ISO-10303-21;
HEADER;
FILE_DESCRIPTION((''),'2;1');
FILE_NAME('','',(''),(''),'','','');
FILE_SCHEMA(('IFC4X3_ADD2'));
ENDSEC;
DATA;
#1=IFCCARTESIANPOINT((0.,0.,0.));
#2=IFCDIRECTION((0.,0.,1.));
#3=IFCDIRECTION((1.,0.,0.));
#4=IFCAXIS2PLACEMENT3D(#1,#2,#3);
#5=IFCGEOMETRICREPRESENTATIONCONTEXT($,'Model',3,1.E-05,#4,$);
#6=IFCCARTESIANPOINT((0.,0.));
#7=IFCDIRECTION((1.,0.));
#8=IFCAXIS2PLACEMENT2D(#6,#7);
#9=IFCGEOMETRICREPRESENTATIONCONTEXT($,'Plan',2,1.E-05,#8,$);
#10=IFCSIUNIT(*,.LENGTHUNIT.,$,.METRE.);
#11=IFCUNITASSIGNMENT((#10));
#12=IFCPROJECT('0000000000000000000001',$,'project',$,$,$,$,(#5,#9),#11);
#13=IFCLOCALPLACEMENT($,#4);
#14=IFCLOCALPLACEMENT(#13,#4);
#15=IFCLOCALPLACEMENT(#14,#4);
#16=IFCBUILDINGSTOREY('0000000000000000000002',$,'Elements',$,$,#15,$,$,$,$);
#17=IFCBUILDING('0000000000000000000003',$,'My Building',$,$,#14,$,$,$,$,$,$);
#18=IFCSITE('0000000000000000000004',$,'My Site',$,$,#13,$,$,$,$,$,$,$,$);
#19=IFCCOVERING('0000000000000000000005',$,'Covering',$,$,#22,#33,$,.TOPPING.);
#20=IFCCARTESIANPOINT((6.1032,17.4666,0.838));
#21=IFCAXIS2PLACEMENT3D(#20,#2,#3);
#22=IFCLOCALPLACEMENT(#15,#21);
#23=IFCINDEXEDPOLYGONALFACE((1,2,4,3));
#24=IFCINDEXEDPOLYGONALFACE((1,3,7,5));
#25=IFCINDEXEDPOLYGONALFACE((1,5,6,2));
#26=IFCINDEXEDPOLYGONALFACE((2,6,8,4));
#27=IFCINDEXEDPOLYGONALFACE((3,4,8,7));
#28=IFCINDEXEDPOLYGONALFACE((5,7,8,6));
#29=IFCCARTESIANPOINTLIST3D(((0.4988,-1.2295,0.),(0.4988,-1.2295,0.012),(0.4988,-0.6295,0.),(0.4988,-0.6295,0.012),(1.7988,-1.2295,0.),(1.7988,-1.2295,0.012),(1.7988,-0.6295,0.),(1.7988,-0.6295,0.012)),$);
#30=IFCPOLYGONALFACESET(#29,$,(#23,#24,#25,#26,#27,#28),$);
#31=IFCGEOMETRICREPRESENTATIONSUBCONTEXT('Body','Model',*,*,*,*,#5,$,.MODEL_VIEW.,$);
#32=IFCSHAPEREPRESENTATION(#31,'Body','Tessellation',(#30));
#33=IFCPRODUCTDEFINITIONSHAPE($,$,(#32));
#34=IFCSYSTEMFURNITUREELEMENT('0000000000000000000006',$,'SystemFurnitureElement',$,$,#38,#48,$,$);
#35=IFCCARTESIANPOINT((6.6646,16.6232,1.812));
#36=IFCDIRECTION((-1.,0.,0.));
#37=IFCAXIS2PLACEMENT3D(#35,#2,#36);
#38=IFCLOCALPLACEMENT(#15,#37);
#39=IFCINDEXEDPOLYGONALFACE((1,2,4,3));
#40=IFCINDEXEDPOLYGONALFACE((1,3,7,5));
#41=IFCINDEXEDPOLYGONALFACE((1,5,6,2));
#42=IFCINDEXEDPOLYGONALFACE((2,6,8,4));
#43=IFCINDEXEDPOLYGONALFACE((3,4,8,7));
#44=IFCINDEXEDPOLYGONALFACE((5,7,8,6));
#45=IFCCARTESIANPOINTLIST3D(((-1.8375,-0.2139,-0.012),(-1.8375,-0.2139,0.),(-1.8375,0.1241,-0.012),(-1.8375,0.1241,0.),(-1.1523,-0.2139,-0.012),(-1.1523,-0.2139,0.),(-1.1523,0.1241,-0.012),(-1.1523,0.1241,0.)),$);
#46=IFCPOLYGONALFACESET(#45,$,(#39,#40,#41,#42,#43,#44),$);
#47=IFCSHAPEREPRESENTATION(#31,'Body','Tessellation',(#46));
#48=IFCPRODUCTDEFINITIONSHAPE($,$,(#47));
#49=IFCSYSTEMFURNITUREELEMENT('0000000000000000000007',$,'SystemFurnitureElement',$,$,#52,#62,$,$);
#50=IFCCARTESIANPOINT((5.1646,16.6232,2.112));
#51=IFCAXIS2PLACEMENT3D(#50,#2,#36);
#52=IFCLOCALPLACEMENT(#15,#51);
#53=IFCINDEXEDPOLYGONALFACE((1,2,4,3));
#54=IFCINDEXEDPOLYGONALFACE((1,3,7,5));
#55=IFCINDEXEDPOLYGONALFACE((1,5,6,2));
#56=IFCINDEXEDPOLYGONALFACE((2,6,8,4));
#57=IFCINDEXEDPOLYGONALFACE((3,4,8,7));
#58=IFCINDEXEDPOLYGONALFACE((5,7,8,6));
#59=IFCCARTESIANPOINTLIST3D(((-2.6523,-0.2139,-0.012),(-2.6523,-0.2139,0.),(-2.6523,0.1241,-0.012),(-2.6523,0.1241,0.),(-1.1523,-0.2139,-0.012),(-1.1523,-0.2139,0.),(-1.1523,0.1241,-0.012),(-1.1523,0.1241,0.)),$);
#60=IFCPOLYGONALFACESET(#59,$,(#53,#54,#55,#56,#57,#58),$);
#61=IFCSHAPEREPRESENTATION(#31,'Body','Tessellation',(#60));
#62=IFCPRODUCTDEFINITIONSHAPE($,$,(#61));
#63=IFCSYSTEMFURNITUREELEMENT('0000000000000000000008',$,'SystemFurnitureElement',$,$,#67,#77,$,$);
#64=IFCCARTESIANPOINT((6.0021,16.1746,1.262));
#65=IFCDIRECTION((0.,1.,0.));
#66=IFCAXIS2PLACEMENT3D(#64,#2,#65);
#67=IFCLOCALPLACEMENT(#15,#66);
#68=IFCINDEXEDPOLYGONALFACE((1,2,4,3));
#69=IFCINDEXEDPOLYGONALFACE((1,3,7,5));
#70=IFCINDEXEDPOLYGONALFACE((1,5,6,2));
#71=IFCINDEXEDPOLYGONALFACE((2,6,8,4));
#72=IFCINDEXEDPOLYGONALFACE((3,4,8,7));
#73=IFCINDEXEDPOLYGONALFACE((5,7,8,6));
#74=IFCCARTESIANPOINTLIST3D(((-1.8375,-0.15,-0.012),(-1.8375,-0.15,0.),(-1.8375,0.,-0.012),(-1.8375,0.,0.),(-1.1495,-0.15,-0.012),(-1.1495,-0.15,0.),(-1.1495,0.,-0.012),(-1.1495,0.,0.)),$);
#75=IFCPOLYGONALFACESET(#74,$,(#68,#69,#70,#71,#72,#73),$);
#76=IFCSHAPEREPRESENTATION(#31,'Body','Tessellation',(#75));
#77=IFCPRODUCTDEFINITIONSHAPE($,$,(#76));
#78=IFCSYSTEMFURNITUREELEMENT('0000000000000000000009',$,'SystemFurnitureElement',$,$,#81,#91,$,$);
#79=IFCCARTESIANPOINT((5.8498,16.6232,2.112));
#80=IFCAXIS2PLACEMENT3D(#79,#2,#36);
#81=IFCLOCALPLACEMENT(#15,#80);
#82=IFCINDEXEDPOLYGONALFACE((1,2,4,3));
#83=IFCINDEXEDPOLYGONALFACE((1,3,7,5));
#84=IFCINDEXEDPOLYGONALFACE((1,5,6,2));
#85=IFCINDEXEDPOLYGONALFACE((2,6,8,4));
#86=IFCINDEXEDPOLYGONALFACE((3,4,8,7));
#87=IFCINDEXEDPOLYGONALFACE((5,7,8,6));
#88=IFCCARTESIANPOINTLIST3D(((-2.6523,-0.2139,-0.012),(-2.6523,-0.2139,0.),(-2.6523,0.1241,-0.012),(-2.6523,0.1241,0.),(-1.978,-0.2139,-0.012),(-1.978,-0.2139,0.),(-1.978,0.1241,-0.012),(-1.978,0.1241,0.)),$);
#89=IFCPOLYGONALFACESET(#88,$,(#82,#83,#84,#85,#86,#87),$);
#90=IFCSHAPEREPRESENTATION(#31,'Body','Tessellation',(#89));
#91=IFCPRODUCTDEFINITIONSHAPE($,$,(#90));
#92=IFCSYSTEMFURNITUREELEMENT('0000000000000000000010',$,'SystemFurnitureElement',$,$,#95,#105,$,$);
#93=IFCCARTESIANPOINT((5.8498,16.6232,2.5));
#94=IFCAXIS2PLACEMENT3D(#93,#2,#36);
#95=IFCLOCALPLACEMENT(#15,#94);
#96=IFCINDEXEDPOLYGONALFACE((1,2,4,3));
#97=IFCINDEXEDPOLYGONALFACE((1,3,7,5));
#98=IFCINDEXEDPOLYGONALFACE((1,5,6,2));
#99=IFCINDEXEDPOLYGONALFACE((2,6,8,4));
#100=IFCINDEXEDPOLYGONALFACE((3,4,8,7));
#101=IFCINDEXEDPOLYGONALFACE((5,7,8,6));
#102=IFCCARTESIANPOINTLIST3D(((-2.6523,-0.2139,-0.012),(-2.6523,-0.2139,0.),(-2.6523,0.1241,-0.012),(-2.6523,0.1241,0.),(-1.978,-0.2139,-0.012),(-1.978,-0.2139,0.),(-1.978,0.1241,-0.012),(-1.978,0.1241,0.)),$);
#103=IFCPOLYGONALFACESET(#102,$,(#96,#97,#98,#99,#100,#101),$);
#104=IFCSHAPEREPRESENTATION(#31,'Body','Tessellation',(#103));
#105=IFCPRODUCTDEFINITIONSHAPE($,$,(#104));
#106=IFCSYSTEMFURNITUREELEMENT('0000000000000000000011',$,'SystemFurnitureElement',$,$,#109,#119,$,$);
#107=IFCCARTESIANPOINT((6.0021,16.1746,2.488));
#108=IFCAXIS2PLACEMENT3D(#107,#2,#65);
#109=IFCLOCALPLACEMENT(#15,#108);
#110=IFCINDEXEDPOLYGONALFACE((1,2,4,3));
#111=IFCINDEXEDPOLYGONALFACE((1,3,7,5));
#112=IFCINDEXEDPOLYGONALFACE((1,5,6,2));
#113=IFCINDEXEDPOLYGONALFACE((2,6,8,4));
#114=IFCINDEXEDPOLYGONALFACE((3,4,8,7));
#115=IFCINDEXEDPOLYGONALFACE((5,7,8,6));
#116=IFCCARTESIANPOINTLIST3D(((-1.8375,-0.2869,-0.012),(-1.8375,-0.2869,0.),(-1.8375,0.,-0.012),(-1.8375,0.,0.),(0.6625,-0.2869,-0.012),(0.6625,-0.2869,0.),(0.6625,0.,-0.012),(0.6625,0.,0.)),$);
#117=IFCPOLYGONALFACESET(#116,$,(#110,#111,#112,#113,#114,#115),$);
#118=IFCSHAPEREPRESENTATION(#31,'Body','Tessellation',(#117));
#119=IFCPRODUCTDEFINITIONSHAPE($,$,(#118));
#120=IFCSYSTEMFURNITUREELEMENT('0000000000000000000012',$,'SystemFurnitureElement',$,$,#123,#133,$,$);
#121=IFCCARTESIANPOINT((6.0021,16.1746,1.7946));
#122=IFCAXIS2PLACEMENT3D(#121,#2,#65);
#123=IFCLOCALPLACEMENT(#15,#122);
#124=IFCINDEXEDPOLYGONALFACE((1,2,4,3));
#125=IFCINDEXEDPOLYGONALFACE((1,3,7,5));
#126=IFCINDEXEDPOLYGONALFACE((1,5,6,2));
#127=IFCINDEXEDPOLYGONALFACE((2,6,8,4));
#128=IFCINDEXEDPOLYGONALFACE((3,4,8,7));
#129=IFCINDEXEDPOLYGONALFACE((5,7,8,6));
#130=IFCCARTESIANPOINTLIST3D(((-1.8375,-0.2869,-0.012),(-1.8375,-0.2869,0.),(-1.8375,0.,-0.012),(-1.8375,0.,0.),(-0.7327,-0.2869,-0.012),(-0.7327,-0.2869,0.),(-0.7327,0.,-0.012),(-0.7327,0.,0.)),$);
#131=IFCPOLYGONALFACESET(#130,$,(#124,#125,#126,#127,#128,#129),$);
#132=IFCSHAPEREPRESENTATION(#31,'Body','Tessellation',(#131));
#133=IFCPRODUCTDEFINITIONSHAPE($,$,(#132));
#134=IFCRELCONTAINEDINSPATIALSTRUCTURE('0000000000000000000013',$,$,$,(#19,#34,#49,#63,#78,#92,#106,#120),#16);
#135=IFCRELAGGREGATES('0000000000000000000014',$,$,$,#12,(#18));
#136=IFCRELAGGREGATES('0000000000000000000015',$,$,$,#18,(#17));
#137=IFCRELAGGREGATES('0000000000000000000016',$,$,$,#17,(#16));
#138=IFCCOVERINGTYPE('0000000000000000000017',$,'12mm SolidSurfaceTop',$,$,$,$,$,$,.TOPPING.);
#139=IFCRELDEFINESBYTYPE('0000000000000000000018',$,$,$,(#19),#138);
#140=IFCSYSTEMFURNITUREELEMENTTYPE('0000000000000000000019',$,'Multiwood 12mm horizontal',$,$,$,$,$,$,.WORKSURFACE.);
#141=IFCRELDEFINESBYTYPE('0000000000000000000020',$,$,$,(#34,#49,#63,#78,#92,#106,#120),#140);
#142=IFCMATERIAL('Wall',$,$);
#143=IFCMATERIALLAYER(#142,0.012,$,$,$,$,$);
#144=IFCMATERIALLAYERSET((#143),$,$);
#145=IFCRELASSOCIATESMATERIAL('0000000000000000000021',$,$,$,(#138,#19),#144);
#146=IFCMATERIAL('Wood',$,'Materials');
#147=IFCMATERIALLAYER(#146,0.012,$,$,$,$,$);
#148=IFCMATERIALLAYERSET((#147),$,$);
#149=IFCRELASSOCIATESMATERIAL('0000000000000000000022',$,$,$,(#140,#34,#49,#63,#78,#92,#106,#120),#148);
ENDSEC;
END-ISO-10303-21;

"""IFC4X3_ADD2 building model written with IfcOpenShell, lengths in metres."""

from ifc_helpers import new_model, si_unit, frame, origin_with_axes, origin_2d_with_axis, place, context, subcontext, project, spatial, indexed_curve, outline, extrude, material, layer, layer_set, layer_usage, type_object, element, save


model = new_model("IFC4X3_ADD2")

# Units and contexts
model_context = context("Model", 3, precision=1e-05, world=origin_with_axes())
plan_context = context("Plan", 2, precision=1e-05, world=origin_2d_with_axis())
body_context = subcontext(model_context, "Body", "Model", "MODEL_VIEW")
ifc_project = project(units=[si_unit("LENGTHUNIT", "METRE")], contexts=[model_context, plan_context])

# Site, building, storey
site_placement = place(None, origin_with_axes())
site = spatial("IfcSite", under=ifc_project, at=site_placement, Name="My Site")
building_placement = place(site_placement, origin_with_axes())
building = spatial("IfcBuilding", under=site, at=building_placement, Name="My Building")
storey_placement = place(building_placement, origin_with_axes())
storey = spatial("IfcBuildingStorey", under=building, at=storey_placement, Name="Elements")

# Covering
ifc_material_1 = material(Name="Wall")
ifc_layer_1 = layer(ifc_material_1, 0.012)
ifc_layer_set_1 = layer_set([ifc_layer_1])
ifc_layer_usage_1 = layer_usage(ifc_layer_set_1, "AXIS3", "POSITIVE", 0.0)
covering_type = type_object("IfcCoveringType", Name="12mm SolidSurfaceTop", PredefinedType="TOPPING", material=ifc_layer_set_1)
covering_placement = place(storey_placement, frame((6.1032, 17.4666, 0.838), z_axis=(0.0, 0.0, 1.0), x_axis=(1.0, 0.0, 0.0)))
element("IfcCovering", 1, at=covering_placement, inside=storey, type_object=covering_type, material=ifc_layer_usage_1, Name="Covering", PredefinedType="TOPPING", context=body_context, shape_type="SweptSolid", body=[
    extrude(outline(indexed_curve([(0.4988, -1.2295), (1.7988, -1.2295), (1.7988, -0.6295), (0.4988, -0.6295), (0.4988, -1.2295)])), None, (0.0, 0.0, 1.0), 0.012),
])

# Shared definitions
ifc_material_2 = material(Name="Wood", Category="Materials")

# System furniture elements
ifc_layer_2 = layer(ifc_material_2, 0.012)
ifc_layer_set_2 = layer_set([ifc_layer_2])
ifc_layer_usage_2 = layer_usage(ifc_layer_set_2, "AXIS3", "POSITIVE", -0.012)
system_furniture_element_type_1 = type_object("IfcSystemFurnitureElementType", Name="Multiwood 12mm horizontal", PredefinedType="WORKSURFACE", material=ifc_layer_set_2)
system_furniture_element_1_placement = place(storey_placement, frame((6.6646, 16.6232, 1.812), z_axis=(0.0, 0.0, 1.0), x_axis=(-1.0, 0.0, 0.0)))
element("IfcSystemFurnitureElement", 2, at=system_furniture_element_1_placement, inside=storey, type_object=system_furniture_element_type_1, material=ifc_layer_usage_2, Name="SystemFurnitureElement", context=body_context, shape_type="SweptSolid", body=[
    extrude(outline(indexed_curve([(-1.8375, -0.2139), (-1.1523, -0.2139), (-1.1523, 0.1241), (-1.8375, 0.1241), (-1.8375, -0.2139)])), frame((0.0, 0.0, -0.012), z_axis=(0.0, 0.0, 1.0), x_axis=(1.0, 0.0, 0.0)), (0.0, 0.0, 1.0), 0.012),
])
ifc_layer_usage_3 = layer_usage(ifc_layer_set_2, "AXIS3", "POSITIVE", -0.012)
system_furniture_element_2_placement = place(storey_placement, frame((5.1646, 16.6232, 2.112), z_axis=(0.0, 0.0, 1.0), x_axis=(-1.0, 0.0, 0.0)))
element("IfcSystemFurnitureElement", 3, at=system_furniture_element_2_placement, inside=storey, type_object=system_furniture_element_type_1, material=ifc_layer_usage_3, Name="SystemFurnitureElement", context=body_context, shape_type="SweptSolid", body=[
    extrude(outline(indexed_curve([(-2.6523, 0.1241), (-1.1523, 0.1241), (-1.1523, -0.2139), (-2.6523, -0.2139), (-2.6523, 0.1241)])), frame((0.0, 0.0, -0.012), z_axis=(0.0, 0.0, 1.0), x_axis=(1.0, 0.0, 0.0)), (0.0, 0.0, 1.0), 0.012),
])
ifc_layer_usage_4 = layer_usage(ifc_layer_set_2, "AXIS3", "POSITIVE", -0.012)
system_furniture_element_3_placement = place(storey_placement, frame((6.0021, 16.1746, 1.262), z_axis=(0.0, 0.0, 1.0), x_axis=(0.0, 1.0, 0.0)))
element("IfcSystemFurnitureElement", 4, at=system_furniture_element_3_placement, inside=storey, type_object=system_furniture_element_type_1, material=ifc_layer_usage_4, Name="SystemFurnitureElement", context=body_context, shape_type="SweptSolid", body=[
    extrude(outline(indexed_curve([(-1.8375, -0.15), (-1.1495, -0.15), (-1.1495, 0.0), (-1.8375, 0.0), (-1.8375, -0.15)])), frame((0.0, 0.0, -0.012), z_axis=(0.0, 0.0, 1.0), x_axis=(1.0, 0.0, 0.0)), (0.0, 0.0, 1.0), 0.012),
])
ifc_layer_usage_5 = layer_usage(ifc_layer_set_2, "AXIS3", "POSITIVE", -0.012)
system_furniture_element_4_placement = place(storey_placement, frame((5.8498, 16.6232, 2.112), z_axis=(0.0, 0.0, 1.0), x_axis=(-1.0, 0.0, 0.0)))
element("IfcSystemFurnitureElement", 5, at=system_furniture_element_4_placement, inside=storey, type_object=system_furniture_element_type_1, material=ifc_layer_usage_5, Name="SystemFurnitureElement", context=body_context, shape_type="SweptSolid", body=[
    extrude(outline(indexed_curve([(-2.6523, -0.2139), (-1.978, -0.2139), (-1.978, 0.1241), (-2.6523, 0.1241), (-2.6523, -0.2139)])), frame((0.0, 0.0, -0.012), z_axis=(0.0, 0.0, 1.0), x_axis=(1.0, 0.0, 0.0)), (0.0, 0.0, 1.0), 0.012),
])
ifc_layer_usage_6 = layer_usage(ifc_layer_set_2, "AXIS3", "POSITIVE", -0.012)
system_furniture_element_5_placement = place(storey_placement, frame((5.8498, 16.6232, 2.5), z_axis=(0.0, 0.0, 1.0), x_axis=(-1.0, 0.0, 0.0)))
element("IfcSystemFurnitureElement", 6, at=system_furniture_element_5_placement, inside=storey, type_object=system_furniture_element_type_1, material=ifc_layer_usage_6, Name="SystemFurnitureElement", context=body_context, shape_type="SweptSolid", body=[
    extrude(outline(indexed_curve([(-2.6523, -0.2139), (-1.978, -0.2139), (-1.978, 0.1241), (-2.6523, 0.1241), (-2.6523, -0.2139)])), frame((0.0, 0.0, -0.012), z_axis=(0.0, 0.0, 1.0), x_axis=(1.0, 0.0, 0.0)), (0.0, 0.0, 1.0), 0.012),
])
ifc_layer_usage_7 = layer_usage(ifc_layer_set_2, "AXIS3", "POSITIVE", -0.012)
system_furniture_element_6_placement = place(storey_placement, frame((6.0021, 16.1746, 2.488), z_axis=(0.0, 0.0, 1.0), x_axis=(0.0, 1.0, 0.0)))
element("IfcSystemFurnitureElement", 7, at=system_furniture_element_6_placement, inside=storey, type_object=system_furniture_element_type_1, material=ifc_layer_usage_7, Name="SystemFurnitureElement", context=body_context, shape_type="SweptSolid", body=[
    extrude(outline(indexed_curve([(-1.8375, -0.2869), (0.6625, -0.2869), (0.6625, 0.0), (-1.8375, 0.0), (-1.8375, -0.2869)])), frame((0.0, 0.0, -0.012), z_axis=(0.0, 0.0, 1.0), x_axis=(1.0, 0.0, 0.0)), (0.0, 0.0, 1.0), 0.012),
])
ifc_layer_usage_8 = layer_usage(ifc_layer_set_2, "AXIS3", "POSITIVE", -0.012)
system_furniture_element_7_placement = place(storey_placement, frame((6.0021, 16.1746, 1.7946), z_axis=(0.0, 0.0, 1.0), x_axis=(0.0, 1.0, 0.0)))
element("IfcSystemFurnitureElement", 8, at=system_furniture_element_7_placement, inside=storey, type_object=system_furniture_element_type_1, material=ifc_layer_usage_8, Name="SystemFurnitureElement", context=body_context, shape_type="SweptSolid", body=[
    extrude(outline(indexed_curve([(-1.8375, 0.0), (-0.7327, 0.0), (-0.7327, -0.2869), (-1.8375, -0.2869), (-1.8375, 0.0)])), frame((0.0, 0.0, -0.012), z_axis=(0.0, 0.0, 1.0), x_axis=(1.0, 0.0, 0.0)), (0.0, 0.0, 1.0), 0.012),
])

save(model, "model.ifc")
